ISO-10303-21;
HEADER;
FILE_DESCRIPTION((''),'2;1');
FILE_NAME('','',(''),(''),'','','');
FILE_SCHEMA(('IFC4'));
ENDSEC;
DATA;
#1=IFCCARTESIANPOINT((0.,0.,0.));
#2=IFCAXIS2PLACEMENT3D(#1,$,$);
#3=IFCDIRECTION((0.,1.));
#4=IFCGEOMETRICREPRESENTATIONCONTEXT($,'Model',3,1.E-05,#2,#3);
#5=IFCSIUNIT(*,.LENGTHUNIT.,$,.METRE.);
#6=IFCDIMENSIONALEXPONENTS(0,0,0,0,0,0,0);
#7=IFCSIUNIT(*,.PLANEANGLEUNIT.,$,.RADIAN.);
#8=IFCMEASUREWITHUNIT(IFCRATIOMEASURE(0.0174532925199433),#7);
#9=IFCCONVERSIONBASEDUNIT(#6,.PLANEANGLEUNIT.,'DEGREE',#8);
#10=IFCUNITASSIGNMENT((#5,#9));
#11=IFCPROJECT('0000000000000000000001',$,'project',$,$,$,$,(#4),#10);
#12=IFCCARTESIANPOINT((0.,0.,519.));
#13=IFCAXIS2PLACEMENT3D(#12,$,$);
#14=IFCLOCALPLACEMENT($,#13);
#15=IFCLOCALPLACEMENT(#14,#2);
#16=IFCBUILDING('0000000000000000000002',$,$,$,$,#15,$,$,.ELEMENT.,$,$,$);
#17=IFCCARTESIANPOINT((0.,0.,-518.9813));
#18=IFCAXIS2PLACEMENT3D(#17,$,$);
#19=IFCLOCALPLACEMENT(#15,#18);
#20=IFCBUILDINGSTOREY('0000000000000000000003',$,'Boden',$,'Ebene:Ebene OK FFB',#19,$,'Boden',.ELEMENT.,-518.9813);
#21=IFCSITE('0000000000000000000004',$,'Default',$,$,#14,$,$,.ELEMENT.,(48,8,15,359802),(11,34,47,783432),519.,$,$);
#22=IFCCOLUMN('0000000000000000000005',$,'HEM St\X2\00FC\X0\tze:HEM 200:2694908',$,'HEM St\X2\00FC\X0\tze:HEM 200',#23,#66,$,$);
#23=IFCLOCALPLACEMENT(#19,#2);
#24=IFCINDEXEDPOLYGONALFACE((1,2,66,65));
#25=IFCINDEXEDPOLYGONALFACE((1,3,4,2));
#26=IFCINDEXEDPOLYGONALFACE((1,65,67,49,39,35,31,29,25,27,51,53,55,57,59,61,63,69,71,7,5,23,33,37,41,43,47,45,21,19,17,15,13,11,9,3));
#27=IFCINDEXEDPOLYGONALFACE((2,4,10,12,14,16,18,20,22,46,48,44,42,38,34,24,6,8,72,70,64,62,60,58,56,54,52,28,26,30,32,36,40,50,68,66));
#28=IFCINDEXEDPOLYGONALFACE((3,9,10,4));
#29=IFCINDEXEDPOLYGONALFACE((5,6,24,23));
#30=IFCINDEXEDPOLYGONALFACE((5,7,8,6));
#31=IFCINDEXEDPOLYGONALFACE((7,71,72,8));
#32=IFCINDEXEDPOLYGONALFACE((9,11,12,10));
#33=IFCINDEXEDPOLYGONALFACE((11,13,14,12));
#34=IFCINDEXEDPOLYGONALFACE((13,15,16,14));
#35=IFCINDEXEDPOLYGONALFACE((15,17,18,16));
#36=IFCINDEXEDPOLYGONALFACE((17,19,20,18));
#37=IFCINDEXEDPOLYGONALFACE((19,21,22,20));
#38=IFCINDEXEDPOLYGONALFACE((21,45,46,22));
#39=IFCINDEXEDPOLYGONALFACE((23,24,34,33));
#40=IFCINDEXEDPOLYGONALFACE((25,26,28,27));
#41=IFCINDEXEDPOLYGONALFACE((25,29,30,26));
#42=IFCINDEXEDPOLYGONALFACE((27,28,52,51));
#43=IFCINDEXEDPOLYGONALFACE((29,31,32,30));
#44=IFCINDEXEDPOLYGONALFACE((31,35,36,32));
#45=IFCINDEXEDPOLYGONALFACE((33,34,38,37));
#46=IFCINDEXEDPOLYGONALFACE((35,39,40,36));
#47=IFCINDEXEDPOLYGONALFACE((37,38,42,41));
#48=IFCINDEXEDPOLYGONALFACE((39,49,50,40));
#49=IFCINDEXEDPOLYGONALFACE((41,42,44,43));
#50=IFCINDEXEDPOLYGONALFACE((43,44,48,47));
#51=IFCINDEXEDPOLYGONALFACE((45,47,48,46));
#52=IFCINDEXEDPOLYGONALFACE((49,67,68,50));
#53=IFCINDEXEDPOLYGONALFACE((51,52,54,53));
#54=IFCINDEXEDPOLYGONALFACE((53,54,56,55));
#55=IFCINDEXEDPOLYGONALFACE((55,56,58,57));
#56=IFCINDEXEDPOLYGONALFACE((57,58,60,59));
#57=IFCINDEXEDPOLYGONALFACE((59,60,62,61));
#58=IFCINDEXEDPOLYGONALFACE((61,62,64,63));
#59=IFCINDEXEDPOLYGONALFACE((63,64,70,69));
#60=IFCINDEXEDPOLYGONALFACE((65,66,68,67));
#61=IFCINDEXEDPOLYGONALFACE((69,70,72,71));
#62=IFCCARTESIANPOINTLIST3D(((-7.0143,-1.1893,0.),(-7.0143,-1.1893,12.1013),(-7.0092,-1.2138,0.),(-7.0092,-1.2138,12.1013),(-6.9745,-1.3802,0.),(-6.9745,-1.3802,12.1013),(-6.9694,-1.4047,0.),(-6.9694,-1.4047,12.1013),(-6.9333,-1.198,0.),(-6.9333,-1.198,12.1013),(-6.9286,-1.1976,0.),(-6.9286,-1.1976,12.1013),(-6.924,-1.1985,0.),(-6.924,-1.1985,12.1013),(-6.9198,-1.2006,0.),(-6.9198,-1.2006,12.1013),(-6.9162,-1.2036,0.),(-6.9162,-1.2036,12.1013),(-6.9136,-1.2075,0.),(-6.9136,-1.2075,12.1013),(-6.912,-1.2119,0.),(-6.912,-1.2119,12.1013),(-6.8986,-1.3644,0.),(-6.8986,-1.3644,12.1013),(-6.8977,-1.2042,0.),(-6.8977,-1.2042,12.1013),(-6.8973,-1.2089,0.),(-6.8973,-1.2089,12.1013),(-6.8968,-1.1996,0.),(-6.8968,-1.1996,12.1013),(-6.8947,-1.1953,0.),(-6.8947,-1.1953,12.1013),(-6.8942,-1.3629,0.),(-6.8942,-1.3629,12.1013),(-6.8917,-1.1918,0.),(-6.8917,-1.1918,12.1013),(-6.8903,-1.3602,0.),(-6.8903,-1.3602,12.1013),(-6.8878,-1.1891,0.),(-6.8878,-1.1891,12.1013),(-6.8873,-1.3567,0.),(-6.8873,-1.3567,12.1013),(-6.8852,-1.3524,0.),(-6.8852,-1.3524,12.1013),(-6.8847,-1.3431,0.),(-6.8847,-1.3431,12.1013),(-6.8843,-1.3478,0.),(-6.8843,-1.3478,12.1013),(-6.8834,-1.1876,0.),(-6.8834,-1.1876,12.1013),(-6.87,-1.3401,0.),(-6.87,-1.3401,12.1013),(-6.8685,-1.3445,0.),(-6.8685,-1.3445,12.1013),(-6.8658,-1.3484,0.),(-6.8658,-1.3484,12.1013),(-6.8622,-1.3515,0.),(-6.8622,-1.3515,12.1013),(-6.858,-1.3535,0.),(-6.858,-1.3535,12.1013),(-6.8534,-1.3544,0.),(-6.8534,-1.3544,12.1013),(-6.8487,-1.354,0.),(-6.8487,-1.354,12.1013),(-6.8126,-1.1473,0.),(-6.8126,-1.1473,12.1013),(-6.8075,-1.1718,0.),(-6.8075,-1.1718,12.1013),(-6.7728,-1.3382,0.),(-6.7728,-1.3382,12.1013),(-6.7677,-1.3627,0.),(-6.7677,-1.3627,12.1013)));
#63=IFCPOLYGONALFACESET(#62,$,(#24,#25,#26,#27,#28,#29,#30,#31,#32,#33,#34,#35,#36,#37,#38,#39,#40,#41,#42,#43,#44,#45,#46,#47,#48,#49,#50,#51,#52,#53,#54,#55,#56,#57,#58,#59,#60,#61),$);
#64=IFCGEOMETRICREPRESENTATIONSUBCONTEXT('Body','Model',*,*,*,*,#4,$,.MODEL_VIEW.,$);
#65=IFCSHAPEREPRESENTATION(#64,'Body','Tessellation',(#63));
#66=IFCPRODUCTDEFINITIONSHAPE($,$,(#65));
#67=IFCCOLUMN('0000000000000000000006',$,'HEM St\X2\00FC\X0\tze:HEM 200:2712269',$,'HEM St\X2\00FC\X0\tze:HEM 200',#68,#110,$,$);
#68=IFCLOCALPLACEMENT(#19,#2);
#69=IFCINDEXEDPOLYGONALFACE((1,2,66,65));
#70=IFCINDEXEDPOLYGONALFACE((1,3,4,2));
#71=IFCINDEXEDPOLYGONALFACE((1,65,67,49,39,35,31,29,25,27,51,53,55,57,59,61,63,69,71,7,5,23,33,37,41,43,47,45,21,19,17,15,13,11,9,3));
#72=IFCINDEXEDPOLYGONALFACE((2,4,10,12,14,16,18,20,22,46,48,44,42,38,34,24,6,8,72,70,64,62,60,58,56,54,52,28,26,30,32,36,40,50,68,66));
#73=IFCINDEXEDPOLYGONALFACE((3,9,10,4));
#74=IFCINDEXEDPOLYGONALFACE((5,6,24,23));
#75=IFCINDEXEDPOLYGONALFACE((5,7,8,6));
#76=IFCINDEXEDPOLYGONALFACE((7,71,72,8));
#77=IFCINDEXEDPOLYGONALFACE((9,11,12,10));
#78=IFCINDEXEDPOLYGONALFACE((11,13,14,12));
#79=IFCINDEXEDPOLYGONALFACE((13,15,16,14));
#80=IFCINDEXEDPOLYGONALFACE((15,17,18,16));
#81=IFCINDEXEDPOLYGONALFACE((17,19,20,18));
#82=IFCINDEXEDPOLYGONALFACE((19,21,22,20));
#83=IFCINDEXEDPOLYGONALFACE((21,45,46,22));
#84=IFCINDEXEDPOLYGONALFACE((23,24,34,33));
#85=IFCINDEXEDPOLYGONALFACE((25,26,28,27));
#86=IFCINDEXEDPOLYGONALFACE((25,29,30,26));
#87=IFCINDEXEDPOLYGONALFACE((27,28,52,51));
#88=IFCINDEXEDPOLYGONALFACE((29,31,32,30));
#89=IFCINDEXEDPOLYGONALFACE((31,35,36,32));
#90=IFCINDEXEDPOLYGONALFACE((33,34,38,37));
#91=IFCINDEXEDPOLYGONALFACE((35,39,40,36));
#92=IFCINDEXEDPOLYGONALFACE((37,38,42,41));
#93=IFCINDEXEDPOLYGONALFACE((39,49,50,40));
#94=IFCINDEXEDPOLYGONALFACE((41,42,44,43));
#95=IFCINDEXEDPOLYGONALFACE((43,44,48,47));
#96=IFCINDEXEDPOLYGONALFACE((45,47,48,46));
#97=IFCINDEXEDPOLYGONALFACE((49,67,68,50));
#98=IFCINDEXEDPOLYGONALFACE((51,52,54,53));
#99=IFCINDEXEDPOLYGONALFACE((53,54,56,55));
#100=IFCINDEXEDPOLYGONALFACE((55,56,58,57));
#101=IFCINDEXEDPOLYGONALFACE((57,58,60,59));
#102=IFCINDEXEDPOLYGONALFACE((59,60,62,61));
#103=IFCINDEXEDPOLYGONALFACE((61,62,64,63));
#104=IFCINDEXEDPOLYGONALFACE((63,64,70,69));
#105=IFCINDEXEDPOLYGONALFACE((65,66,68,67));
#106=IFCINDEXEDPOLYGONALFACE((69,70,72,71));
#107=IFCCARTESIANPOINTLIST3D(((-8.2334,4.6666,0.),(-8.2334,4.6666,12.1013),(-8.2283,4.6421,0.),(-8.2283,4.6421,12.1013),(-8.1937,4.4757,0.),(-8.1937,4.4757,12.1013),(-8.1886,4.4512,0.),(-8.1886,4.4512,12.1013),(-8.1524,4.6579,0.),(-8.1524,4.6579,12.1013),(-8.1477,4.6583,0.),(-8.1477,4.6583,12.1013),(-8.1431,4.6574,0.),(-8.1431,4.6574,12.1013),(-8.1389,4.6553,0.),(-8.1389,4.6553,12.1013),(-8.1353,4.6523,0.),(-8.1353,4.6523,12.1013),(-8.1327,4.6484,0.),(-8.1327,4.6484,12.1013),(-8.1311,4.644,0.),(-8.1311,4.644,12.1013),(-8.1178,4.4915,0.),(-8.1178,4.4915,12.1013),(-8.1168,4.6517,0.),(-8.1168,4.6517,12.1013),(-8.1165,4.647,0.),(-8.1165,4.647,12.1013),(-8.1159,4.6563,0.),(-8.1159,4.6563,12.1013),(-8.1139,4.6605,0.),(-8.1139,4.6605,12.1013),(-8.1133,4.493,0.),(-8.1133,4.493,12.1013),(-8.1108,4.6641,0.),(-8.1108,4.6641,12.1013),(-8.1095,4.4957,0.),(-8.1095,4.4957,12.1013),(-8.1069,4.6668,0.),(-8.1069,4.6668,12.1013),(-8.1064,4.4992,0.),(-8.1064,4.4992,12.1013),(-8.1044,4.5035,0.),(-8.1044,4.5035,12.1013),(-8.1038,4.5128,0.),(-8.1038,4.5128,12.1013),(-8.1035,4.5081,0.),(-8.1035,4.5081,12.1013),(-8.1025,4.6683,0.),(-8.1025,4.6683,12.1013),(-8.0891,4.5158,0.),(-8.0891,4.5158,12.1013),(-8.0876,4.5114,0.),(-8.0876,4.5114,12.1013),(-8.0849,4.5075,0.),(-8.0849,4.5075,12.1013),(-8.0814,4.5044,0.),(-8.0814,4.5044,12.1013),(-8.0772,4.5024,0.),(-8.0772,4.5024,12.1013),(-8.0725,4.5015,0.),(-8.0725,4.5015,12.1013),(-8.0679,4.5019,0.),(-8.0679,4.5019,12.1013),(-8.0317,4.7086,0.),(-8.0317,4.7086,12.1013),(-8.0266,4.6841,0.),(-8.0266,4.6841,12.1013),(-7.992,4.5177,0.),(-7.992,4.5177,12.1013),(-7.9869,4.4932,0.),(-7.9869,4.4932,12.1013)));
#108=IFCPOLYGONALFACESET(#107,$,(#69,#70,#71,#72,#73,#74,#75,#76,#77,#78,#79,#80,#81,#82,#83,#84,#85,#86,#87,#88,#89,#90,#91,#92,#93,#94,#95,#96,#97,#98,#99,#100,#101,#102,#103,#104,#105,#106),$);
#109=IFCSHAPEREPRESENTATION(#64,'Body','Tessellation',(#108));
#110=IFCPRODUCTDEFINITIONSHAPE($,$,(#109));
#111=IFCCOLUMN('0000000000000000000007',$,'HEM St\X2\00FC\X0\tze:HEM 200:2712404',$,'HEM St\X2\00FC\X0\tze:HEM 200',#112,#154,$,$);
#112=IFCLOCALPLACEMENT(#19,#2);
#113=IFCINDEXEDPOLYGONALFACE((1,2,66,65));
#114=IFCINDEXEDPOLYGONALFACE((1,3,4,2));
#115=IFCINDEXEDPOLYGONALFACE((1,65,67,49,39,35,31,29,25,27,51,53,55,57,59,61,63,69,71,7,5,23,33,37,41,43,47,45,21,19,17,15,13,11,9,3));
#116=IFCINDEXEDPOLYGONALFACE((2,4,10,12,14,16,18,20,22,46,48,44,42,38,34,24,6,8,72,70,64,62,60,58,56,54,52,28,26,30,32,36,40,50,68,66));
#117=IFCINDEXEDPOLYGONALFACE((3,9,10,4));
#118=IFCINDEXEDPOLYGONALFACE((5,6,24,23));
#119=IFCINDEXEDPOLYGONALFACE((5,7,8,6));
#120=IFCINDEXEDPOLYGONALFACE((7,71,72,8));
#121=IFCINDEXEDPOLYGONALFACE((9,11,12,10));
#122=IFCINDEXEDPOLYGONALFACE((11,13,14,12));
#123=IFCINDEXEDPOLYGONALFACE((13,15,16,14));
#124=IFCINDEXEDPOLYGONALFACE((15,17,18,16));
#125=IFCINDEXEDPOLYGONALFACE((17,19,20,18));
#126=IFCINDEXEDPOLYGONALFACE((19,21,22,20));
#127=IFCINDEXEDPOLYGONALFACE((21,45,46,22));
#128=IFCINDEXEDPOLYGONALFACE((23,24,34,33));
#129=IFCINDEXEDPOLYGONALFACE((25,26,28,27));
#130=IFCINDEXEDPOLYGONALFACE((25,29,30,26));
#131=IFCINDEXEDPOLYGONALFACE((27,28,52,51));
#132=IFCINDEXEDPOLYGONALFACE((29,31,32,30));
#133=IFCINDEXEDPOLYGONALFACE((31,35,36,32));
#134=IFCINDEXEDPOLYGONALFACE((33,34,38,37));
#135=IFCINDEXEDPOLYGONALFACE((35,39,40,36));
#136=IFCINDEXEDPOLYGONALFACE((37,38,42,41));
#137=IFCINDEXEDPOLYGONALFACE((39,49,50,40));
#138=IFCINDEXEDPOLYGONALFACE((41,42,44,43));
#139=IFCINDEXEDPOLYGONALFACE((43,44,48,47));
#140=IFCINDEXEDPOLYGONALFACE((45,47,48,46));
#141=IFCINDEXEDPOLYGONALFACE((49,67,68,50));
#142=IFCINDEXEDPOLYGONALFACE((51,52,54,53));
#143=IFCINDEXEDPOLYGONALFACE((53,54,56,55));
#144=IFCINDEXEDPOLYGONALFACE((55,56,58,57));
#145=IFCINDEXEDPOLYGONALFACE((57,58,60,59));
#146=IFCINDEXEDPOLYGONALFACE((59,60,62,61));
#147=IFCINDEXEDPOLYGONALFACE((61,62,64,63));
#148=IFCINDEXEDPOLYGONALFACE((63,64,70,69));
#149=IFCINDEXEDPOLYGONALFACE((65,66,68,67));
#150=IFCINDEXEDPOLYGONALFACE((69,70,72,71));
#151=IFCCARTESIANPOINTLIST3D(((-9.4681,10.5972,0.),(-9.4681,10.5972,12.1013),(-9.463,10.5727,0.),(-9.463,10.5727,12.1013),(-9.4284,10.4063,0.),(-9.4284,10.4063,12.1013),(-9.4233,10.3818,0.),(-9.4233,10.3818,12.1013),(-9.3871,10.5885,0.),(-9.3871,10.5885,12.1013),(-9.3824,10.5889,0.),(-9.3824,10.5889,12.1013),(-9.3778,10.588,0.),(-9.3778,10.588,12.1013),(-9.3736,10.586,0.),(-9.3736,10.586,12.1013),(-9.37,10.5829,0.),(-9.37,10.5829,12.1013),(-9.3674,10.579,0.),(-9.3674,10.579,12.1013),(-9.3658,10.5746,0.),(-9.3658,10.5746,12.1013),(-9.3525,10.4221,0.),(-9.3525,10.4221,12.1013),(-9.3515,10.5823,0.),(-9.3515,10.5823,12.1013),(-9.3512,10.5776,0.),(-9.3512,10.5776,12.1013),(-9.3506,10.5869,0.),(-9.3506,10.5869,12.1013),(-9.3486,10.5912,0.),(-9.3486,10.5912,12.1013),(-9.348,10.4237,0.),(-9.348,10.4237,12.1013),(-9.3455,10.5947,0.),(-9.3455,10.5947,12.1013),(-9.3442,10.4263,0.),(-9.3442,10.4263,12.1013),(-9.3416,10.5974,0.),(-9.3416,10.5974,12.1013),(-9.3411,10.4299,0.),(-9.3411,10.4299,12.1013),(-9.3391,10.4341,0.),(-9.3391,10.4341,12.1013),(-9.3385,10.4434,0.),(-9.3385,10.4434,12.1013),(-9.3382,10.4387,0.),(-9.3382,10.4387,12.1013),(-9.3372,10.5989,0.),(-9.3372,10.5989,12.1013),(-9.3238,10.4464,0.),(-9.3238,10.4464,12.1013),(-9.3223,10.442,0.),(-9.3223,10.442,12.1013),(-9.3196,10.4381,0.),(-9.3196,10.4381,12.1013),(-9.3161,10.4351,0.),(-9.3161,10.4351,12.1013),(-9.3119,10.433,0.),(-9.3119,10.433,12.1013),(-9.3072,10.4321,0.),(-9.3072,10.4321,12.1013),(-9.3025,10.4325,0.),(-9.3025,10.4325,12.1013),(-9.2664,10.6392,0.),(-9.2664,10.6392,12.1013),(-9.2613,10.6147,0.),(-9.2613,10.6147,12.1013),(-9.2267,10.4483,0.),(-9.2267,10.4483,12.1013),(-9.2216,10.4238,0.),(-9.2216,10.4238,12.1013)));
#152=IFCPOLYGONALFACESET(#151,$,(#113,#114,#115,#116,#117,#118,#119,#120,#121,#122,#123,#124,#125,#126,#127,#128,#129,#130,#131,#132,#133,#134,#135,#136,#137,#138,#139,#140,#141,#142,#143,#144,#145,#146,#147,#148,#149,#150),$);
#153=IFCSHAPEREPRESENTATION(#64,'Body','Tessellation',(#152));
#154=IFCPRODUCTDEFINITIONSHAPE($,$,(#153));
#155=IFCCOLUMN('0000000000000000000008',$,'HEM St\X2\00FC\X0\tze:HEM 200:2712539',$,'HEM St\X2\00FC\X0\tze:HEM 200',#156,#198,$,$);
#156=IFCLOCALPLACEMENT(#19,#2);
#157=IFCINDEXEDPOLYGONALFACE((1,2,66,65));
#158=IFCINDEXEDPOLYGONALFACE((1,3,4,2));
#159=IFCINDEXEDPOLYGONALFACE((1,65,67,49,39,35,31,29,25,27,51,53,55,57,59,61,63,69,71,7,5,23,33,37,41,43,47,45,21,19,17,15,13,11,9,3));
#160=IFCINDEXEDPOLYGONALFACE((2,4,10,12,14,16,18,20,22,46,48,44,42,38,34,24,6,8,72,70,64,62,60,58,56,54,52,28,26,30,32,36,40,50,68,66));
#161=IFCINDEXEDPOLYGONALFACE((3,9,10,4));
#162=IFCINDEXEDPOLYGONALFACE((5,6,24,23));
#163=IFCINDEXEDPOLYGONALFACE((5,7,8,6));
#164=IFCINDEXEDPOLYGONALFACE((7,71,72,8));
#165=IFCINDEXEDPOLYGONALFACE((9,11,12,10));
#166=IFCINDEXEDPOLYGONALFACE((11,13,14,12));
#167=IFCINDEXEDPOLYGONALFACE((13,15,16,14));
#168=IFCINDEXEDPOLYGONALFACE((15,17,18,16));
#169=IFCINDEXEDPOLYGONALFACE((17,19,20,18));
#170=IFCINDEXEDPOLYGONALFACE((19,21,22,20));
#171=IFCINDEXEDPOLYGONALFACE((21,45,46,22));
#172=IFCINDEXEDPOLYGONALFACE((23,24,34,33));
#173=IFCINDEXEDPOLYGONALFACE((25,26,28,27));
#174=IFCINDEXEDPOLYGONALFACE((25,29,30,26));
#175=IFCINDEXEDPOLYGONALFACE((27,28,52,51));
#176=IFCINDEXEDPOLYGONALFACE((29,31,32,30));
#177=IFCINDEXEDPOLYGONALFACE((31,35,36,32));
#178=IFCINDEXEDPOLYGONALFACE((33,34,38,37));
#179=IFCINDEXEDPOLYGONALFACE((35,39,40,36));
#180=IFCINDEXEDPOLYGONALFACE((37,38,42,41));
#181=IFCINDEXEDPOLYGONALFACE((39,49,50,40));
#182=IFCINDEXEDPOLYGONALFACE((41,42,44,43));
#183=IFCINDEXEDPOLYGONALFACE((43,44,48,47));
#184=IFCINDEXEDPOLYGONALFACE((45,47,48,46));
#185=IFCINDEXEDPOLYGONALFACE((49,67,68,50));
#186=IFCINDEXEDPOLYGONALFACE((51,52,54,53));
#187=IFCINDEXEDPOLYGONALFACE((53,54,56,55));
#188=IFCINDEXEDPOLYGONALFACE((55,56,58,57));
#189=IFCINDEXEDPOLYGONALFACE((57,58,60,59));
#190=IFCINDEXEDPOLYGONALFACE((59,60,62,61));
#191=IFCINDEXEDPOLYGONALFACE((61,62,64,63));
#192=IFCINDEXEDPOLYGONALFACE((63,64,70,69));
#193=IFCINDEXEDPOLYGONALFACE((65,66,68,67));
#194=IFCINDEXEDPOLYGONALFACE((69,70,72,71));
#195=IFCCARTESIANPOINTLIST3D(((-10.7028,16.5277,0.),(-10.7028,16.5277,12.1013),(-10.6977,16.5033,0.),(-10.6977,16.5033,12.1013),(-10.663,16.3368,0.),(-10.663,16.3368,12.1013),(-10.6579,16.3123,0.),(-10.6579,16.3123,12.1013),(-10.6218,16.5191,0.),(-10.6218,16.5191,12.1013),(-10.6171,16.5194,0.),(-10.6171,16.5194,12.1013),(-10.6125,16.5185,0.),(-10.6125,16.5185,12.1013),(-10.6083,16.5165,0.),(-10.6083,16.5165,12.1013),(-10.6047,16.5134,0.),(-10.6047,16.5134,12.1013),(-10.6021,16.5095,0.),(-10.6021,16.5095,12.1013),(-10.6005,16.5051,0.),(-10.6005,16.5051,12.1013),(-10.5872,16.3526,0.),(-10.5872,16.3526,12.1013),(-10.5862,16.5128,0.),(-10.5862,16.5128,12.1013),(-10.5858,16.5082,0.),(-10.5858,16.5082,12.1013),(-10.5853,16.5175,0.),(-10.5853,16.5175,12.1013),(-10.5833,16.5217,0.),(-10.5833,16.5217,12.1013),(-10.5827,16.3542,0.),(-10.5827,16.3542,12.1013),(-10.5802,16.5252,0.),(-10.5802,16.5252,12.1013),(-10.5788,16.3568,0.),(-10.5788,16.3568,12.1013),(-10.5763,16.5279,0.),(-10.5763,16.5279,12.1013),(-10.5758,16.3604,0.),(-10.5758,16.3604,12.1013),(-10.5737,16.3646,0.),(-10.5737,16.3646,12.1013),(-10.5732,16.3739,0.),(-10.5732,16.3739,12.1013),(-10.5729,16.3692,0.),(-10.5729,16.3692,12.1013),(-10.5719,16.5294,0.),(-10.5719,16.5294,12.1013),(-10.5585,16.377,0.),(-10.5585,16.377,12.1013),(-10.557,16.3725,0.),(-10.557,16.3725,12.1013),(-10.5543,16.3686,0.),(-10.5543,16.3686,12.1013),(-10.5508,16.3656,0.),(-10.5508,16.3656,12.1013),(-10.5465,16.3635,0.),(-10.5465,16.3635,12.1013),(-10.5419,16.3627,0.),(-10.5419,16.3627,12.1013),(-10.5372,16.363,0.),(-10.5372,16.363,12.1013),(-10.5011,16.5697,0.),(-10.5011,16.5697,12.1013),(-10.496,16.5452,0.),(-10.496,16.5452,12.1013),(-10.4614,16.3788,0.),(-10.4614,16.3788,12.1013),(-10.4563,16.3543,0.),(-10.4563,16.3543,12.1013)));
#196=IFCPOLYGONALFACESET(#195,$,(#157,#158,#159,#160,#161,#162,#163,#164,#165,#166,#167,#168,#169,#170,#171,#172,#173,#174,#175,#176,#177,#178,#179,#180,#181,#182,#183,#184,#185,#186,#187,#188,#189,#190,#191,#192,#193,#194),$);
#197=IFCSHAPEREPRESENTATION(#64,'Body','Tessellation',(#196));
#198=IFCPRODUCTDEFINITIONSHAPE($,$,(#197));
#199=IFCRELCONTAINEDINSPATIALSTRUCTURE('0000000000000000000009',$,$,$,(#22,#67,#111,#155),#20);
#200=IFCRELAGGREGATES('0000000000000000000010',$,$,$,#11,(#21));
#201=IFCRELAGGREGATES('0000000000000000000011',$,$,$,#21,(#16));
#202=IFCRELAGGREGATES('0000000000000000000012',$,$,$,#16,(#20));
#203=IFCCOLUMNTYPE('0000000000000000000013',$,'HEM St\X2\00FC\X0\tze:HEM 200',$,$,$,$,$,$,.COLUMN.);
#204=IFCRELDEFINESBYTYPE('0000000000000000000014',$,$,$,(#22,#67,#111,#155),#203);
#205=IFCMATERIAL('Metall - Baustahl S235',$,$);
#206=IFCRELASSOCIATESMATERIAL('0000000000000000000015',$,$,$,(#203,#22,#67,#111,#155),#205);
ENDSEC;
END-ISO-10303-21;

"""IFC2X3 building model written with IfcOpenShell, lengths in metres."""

from ifc_helpers import new_model, entity, si_unit, converted_unit, direction, frame, frame_2d, origin, place, context, subcontext, project, spatial, polyline, circle_curve, parameter, trimmed, segment, composite_curve, outline, extrude, source, transform, mapped, material, type_object, type_shapes, element, save


model = new_model("IFC2X3")

# Units and contexts
model_context = context("Model", 3, precision=1e-05, world=origin(), true_north=direction((0.0, 1.0)))
body_context = subcontext(model_context, "Body", "Model", "MODEL_VIEW")
ifc_project = project(units=[si_unit("LENGTHUNIT", "METRE"), converted_unit("PLANEANGLEUNIT", "DEGREE", entity("IfcRatioMeasure", 0.0174532925199433), si_unit("PLANEANGLEUNIT", "RADIAN"), dimensions=[0, 0, 0, 0, 0, 0, 0])], contexts=[model_context])

# Site, building, storey
site_placement = place(None, frame((0.0, 0.0, 519.0)))
site = spatial("IfcSite", under=ifc_project, at=site_placement, Name="Default", CompositionType="ELEMENT", RefLatitude=(48, 8, 15, 359802), RefLongitude=(11, 34, 47, 783432), RefElevation=519.0)
building_placement = place(site_placement, origin())
building = spatial("IfcBuilding", under=site, at=building_placement, CompositionType="ELEMENT")
storey_placement = place(building_placement, frame((0.0, 0.0, -518.9813)))
storey = spatial("IfcBuildingStorey", under=building, at=storey_placement, Name="Boden", ObjectType="Ebene:Ebene OK FFB", LongName="Boden", CompositionType="ELEMENT", Elevation=-518.9813)

# Columns
ifc_material_1 = material(Name="Metall - Baustahl S235")
column_type_1 = type_object("IfcColumnType", Name="HEM Stütze:HEM 200", PredefinedType="COLUMN", material=ifc_material_1)
shared_shape_1 = source(origin(), body_context, "Body", "SweptSolid", [
    extrude(outline(composite_curve([segment(polyline([(0.085, -0.103), (0.11, -0.103)]), True, "CONTINUOUS"), segment(polyline([(0.11, -0.103), (0.11, 0.103)]), True, "CONTINUOUS"), segment(polyline([(0.11, 0.103), (0.085, 0.103)]), True, "CONTINUOUS"), segment(polyline([(0.085, 0.103), (0.085, 0.0255)]), True, "CONTINUOUS"), segment(trimmed(circle_curve(frame_2d((0.067, 0.0255), x_axis=(1.0, 0.0)), 0.018), [parameter(270.0)], [parameter(0.0)], True, "PARAMETER"), False, "CONTINUOUS"), segment(polyline([(0.067, 0.0075), (-0.067, 0.0075)]), True, "CONTINUOUS"), segment(trimmed(circle_curve(frame_2d((-0.067, 0.0255), x_axis=(0.0, -1.0)), 0.018), [parameter(270.0)], [parameter(0.0)], True, "PARAMETER"), False, "CONTINUOUS"), segment(polyline([(-0.085, 0.0255), (-0.085, 0.103)]), True, "CONTINUOUS"), segment(polyline([(-0.085, 0.103), (-0.11, 0.103)]), True, "CONTINUOUS"), segment(polyline([(-0.11, 0.103), (-0.11, -0.103)]), True, "CONTINUOUS"), segment(polyline([(-0.11, -0.103), (-0.085, -0.103)]), True, "CONTINUOUS"), segment(polyline([(-0.085, -0.103), (-0.085, -0.0255)]), True, "CONTINUOUS"), segment(trimmed(circle_curve(frame_2d((-0.067, -0.0255), x_axis=(-1.0, 0.0)), 0.018), [parameter(270.0)], [parameter(0.0)], True, "PARAMETER"), False, "CONTINUOUS"), segment(polyline([(-0.067, -0.0075), (0.067, -0.0075)]), True, "CONTINUOUS"), segment(trimmed(circle_curve(frame_2d((0.067, -0.0255), x_axis=(0.0, 1.0)), 0.018), [parameter(270.0)], [parameter(0.0)], True, "PARAMETER"), False, "CONTINUOUS"), segment(polyline([(0.085, -0.0255), (0.085, -0.103)]), True, "CONTINUOUS")], self_intersect=False)), frame((0.0, 0.0, -518.9813), z_axis=(0.0, 0.0, 1.0), x_axis=(0.0, -1.0, 0.0)), (0.0, 0.0, 1.0), 12.1013),
])
type_shapes(column_type_1, [shared_shape_1])
for number, where, z_axis, x_axis, name in (
    (1, (-6.891, -1.276, 518.9813), (0.0, 0.0, 1.0), (0.979008, 0.20382, 0.0), "HEM Stütze:HEM 200:2694908"),
    (2, (-8.1101, 4.5799, 518.9813), (0.0, 0.0, 1.0), (0.979008, 0.20382, 0.0), "HEM Stütze:HEM 200:2712269"),
    (3, (-9.3448, 10.5105, 518.9813), (0.0, 0.0, 1.0), (0.979008, 0.20382, 0.0), "HEM Stütze:HEM 200:2712404"),
    (4, (-10.5795, 16.441, 518.9813), (0.0, 0.0, 1.0), (0.979008, 0.20382, 0.0), "HEM Stütze:HEM 200:2712539"),
):
    element("IfcColumn", number, at=place(storey_placement, frame(where, z_axis=z_axis, x_axis=x_axis)), inside=storey, type_object=column_type_1, material=ifc_material_1, Name=name, ObjectType="HEM Stütze:HEM 200", context=body_context, shape_type="MappedRepresentation", body=[
        mapped(shared_shape_1, transform((0.0, 0.0, 0.0), scale=1.0)),
    ])

save(model, "model.ifc")
